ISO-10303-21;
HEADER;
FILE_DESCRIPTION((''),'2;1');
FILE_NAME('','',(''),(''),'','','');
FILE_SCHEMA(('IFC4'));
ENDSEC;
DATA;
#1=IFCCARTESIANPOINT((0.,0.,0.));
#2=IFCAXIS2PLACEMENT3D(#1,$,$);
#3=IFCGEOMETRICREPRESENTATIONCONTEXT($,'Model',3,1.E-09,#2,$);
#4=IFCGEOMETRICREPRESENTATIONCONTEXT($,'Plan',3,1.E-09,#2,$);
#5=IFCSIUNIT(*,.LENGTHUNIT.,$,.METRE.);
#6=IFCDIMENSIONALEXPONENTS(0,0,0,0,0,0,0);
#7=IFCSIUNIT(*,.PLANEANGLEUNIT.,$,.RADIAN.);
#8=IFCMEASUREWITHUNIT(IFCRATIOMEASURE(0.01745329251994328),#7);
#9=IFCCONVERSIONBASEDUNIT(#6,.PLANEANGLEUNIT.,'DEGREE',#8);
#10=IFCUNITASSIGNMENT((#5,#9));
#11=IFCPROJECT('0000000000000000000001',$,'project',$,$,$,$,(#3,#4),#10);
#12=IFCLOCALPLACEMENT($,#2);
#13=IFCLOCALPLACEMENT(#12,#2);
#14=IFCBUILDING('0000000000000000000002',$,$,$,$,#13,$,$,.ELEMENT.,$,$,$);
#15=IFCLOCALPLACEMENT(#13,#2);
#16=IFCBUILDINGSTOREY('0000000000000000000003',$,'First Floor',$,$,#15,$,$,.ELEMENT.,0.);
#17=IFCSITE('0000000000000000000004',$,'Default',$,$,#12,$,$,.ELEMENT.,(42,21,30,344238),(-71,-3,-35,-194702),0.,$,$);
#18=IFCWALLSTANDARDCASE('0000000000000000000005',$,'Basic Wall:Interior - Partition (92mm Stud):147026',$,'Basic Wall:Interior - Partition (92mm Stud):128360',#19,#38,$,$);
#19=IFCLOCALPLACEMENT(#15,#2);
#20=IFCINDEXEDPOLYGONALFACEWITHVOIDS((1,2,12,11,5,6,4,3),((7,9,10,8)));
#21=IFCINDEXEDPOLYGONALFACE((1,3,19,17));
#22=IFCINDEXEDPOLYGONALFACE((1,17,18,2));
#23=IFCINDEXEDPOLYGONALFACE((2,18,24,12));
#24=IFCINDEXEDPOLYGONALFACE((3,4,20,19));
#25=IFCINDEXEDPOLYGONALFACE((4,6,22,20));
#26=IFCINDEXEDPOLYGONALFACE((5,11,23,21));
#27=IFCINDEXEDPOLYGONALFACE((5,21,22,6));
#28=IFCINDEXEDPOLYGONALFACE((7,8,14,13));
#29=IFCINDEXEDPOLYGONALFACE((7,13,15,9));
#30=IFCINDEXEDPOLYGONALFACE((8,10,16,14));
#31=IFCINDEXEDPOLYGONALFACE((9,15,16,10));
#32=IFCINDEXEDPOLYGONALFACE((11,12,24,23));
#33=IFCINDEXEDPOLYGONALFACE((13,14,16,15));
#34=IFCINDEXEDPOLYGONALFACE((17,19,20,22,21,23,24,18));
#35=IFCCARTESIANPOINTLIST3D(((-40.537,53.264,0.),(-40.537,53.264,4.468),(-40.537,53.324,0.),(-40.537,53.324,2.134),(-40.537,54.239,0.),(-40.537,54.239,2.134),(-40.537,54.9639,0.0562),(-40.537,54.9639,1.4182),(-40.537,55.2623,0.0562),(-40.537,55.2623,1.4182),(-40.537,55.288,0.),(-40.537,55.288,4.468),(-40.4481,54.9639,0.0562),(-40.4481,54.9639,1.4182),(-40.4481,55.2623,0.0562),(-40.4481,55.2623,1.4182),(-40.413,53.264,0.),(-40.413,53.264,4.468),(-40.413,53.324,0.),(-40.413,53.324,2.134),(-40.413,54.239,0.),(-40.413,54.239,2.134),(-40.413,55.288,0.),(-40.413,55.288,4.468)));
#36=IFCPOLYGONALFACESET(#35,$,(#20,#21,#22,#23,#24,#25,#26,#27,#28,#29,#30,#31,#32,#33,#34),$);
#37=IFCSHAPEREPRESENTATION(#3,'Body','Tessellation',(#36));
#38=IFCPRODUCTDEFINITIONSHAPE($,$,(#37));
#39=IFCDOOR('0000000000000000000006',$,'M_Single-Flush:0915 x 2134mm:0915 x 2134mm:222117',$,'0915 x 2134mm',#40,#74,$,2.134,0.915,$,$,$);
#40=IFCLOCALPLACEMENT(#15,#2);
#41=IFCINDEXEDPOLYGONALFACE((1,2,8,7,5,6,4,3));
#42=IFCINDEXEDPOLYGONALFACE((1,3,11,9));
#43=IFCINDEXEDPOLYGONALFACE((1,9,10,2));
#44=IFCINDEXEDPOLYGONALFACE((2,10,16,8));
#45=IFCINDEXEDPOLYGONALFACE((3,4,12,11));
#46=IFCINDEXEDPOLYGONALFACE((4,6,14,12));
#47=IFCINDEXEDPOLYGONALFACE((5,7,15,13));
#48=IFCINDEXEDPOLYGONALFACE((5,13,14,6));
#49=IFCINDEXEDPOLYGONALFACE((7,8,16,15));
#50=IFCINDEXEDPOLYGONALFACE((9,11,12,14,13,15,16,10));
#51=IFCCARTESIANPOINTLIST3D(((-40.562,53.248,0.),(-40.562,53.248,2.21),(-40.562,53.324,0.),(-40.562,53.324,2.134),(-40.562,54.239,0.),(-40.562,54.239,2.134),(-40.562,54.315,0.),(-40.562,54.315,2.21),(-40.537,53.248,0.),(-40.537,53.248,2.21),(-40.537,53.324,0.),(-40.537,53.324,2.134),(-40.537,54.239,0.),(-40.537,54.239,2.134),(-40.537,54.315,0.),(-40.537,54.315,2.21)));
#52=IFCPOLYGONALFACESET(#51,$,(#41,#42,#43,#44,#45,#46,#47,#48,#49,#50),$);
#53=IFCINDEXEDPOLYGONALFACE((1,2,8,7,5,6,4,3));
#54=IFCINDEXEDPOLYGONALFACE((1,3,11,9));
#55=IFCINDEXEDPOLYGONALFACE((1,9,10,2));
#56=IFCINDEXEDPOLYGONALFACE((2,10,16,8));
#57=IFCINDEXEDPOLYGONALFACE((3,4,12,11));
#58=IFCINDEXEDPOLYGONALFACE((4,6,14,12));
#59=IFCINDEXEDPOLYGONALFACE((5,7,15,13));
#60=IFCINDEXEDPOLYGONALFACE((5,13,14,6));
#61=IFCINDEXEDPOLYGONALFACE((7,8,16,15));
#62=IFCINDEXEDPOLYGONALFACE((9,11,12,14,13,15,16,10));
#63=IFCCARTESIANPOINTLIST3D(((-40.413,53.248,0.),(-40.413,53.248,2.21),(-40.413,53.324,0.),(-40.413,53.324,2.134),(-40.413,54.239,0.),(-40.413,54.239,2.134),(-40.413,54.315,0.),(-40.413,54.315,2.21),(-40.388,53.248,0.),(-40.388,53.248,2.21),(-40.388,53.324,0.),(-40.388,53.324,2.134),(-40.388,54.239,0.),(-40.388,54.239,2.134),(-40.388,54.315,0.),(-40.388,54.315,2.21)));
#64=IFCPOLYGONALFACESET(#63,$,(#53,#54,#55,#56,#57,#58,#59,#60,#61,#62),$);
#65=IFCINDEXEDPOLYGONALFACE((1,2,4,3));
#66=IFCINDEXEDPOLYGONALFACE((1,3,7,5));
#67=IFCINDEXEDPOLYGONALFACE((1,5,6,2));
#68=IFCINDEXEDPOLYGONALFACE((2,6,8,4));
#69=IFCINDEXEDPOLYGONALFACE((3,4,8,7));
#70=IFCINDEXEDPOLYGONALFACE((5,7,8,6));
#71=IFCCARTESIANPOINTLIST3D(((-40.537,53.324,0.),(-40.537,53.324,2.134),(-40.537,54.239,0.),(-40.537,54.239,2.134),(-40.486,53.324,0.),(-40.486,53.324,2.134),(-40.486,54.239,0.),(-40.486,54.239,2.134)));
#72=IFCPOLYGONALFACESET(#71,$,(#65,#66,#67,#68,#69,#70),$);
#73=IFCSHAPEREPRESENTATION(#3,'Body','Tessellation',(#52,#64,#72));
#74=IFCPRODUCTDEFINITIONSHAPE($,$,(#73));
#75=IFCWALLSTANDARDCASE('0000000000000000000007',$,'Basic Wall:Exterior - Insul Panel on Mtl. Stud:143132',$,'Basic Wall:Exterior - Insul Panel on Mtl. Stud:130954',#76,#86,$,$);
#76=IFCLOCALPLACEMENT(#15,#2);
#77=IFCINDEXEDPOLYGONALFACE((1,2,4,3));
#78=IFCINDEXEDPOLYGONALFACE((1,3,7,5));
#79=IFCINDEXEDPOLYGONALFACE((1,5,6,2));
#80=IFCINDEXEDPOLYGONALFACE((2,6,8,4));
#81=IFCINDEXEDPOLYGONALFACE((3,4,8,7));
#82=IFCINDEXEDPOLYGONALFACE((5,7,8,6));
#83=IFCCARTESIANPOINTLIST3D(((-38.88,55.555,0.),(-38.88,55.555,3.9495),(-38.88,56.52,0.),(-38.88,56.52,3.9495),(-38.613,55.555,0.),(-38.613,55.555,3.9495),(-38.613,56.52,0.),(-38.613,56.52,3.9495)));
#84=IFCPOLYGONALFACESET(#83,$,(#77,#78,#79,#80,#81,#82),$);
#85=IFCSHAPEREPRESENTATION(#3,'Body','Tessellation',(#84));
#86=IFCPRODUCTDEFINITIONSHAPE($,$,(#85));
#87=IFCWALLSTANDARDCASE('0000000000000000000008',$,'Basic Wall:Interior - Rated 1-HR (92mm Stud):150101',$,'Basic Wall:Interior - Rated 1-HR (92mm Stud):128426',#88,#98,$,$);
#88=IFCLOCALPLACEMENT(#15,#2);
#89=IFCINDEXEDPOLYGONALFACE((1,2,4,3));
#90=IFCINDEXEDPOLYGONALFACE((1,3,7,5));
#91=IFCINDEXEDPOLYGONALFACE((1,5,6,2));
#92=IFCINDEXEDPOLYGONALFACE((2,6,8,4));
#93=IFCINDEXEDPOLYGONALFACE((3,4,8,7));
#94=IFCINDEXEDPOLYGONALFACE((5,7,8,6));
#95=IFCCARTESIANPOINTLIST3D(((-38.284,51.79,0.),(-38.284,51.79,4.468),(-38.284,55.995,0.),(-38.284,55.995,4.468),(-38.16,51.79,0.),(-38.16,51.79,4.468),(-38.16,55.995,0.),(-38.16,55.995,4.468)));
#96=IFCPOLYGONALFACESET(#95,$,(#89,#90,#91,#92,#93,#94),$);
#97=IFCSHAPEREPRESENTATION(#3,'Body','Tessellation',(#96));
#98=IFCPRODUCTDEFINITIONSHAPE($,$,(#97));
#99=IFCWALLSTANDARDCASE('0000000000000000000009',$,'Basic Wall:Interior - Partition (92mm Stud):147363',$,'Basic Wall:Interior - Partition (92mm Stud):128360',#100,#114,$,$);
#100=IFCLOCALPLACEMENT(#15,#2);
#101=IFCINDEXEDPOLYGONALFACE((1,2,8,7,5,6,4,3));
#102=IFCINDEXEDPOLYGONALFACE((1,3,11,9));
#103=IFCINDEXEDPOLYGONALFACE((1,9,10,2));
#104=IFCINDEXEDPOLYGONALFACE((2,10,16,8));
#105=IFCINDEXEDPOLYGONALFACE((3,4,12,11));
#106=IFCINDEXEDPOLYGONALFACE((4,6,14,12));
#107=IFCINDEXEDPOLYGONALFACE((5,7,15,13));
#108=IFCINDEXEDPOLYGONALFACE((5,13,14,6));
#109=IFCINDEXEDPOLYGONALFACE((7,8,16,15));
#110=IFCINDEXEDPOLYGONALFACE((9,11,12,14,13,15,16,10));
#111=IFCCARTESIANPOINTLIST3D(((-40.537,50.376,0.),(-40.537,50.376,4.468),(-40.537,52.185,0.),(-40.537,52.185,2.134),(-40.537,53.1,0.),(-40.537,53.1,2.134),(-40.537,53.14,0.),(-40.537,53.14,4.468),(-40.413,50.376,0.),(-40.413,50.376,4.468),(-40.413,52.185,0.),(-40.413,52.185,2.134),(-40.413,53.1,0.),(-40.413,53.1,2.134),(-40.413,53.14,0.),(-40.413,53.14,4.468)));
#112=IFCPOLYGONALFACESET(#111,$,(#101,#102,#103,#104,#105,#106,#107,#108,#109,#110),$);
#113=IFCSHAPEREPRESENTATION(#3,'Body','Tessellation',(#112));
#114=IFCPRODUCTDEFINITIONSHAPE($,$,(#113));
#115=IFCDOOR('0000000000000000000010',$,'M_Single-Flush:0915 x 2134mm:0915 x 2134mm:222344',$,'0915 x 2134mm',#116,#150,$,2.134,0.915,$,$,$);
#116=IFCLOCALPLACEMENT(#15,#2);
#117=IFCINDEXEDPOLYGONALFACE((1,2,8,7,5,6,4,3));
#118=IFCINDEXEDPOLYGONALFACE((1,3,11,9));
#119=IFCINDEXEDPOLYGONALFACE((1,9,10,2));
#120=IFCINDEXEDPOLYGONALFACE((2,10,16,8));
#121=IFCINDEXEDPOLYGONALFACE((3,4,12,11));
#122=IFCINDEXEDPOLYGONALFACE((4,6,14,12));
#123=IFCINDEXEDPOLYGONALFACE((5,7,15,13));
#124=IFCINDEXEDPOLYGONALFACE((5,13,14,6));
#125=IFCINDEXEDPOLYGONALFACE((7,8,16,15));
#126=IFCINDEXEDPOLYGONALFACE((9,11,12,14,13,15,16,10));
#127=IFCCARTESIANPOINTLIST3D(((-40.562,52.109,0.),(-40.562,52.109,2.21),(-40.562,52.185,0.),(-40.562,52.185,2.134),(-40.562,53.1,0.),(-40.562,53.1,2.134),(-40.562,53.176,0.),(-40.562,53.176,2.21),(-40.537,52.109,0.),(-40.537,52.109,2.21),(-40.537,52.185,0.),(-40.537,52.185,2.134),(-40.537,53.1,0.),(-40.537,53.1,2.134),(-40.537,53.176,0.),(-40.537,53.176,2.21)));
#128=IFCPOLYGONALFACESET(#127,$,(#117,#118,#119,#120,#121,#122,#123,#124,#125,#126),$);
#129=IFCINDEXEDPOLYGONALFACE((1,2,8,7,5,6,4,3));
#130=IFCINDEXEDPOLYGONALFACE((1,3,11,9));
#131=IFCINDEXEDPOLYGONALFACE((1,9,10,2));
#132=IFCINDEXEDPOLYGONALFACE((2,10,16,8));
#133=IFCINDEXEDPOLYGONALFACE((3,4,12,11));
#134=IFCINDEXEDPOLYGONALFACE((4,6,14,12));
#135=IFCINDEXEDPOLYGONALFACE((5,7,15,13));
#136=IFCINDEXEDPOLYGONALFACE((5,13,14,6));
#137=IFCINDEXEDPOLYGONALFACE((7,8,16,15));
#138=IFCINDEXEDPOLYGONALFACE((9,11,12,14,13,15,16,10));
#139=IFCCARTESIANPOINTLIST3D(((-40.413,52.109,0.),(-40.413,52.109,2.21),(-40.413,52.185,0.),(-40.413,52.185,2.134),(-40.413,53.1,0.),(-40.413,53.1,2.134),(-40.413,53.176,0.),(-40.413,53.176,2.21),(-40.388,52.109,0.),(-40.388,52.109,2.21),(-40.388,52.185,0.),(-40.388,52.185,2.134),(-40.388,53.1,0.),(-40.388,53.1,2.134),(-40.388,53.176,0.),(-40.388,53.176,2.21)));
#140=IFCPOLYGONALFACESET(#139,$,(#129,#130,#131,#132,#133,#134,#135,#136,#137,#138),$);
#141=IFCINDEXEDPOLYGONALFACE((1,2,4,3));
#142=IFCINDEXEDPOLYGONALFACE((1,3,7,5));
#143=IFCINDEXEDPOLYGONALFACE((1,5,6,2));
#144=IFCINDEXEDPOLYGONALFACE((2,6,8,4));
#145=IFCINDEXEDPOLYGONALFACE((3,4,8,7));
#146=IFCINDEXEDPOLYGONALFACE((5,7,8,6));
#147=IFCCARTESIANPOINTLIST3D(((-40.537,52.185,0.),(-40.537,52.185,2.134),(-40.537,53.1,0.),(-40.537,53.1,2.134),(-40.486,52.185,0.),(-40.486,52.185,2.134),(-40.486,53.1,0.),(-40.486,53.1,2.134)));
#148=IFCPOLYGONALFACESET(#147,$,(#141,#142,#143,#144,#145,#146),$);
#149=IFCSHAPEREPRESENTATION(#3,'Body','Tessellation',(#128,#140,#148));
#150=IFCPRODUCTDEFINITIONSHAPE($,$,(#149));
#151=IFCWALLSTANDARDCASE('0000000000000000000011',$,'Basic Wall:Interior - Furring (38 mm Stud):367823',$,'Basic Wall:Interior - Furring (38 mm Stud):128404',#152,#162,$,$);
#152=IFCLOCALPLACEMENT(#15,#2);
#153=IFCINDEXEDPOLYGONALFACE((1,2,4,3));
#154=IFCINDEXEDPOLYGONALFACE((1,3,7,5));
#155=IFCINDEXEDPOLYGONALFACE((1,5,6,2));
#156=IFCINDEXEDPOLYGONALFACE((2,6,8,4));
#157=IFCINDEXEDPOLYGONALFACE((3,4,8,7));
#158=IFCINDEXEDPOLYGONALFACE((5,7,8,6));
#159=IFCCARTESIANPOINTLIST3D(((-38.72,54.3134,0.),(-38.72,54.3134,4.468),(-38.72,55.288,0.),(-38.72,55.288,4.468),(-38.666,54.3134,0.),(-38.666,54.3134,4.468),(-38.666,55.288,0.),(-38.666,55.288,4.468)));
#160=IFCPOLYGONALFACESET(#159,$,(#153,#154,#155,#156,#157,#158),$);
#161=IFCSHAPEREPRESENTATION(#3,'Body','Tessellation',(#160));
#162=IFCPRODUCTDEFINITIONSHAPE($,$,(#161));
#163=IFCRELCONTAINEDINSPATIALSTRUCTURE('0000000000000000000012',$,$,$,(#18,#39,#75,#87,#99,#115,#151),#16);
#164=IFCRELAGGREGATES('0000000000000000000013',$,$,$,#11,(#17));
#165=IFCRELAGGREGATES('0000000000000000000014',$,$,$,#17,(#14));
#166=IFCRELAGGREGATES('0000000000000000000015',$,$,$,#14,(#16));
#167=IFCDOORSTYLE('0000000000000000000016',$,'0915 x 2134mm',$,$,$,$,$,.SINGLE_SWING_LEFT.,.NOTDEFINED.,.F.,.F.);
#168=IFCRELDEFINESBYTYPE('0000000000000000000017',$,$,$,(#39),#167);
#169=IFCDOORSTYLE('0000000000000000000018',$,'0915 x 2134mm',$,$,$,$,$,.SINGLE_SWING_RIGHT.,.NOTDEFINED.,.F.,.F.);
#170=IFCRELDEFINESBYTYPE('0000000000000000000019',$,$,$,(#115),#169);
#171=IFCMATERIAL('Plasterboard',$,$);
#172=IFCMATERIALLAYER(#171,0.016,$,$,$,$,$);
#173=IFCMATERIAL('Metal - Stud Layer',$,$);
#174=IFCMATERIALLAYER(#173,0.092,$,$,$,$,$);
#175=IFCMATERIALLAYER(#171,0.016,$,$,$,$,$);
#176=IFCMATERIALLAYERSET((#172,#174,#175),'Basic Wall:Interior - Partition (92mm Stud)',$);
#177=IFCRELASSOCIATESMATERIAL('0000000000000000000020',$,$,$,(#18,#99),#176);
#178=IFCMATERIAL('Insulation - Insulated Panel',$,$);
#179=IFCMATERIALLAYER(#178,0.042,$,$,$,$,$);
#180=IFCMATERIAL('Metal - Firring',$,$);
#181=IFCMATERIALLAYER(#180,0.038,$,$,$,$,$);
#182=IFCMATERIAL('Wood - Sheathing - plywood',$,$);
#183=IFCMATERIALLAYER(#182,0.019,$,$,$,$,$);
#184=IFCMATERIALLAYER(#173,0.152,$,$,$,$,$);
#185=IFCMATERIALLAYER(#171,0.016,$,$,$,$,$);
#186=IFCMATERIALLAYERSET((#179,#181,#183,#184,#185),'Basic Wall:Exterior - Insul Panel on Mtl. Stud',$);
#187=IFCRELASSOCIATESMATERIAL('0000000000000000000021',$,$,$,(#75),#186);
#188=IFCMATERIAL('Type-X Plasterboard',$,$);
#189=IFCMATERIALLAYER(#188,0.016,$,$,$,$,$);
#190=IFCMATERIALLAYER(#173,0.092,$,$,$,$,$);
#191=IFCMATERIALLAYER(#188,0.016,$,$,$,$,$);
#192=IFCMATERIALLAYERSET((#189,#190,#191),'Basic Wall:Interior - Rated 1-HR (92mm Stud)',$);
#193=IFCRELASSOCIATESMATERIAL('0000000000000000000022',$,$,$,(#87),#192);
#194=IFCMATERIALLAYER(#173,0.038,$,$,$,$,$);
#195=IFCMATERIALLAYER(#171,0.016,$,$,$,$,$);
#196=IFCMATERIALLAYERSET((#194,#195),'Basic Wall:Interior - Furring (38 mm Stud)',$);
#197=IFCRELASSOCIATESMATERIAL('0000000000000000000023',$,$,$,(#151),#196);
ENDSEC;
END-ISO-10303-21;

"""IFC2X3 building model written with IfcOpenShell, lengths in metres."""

from ifc_helpers import new_model, entity, si_unit, converted_unit, frame, frame_2d, origin, origin_2d_with_axis, place, context, project, spatial, polyline, rectangle, outline, extrude, source, transform, mapped, material, layer, layer_set, layer_usage, type_object, type_shapes, element, fill, save


model = new_model("IFC2X3")

# Units and contexts
model_context = context("Model", 3, precision=1e-09, world=origin())
plan_context = context("Plan", 3, precision=1e-09, world=origin())
ifc_project = project(units=[si_unit("LENGTHUNIT", "METRE"), converted_unit("PLANEANGLEUNIT", "DEGREE", entity("IfcRatioMeasure", 0.01745329251994328), si_unit("PLANEANGLEUNIT", "RADIAN"), dimensions=[0, 0, 0, 0, 0, 0, 0])], contexts=[model_context, plan_context])

# Site, building, storey
site_placement = place(None, origin())
site = spatial("IfcSite", under=ifc_project, at=site_placement, Name="Default", CompositionType="ELEMENT", RefLatitude=(42, 21, 30, 344238), RefLongitude=(-71, -3, -35, -194702), RefElevation=0.0)
building_placement = place(site_placement, origin())
building = spatial("IfcBuilding", under=site, at=building_placement, CompositionType="ELEMENT")
storey_placement = place(building_placement, origin())
storey = spatial("IfcBuildingStorey", under=building, at=storey_placement, Name="First Floor", CompositionType="ELEMENT", Elevation=0.0)

# Shared definitions
ifc_material_1 = material(Name="Insulation - Insulated Panel")
ifc_layer_1 = layer(ifc_material_1, 0.042)
ifc_material_2 = material(Name="Metal - Firring")
ifc_layer_2 = layer(ifc_material_2, 0.038)
ifc_material_3 = material(Name="Wood - Sheathing - plywood")
ifc_layer_3 = layer(ifc_material_3, 0.019)
ifc_material_4 = material(Name="Metal - Stud Layer")
ifc_layer_4 = layer(ifc_material_4, 0.152)
ifc_material_5 = material(Name="Plasterboard")
ifc_layer_5 = layer(ifc_material_5, 0.016)
ifc_layer_set_1 = layer_set([ifc_layer_1, ifc_layer_2, ifc_layer_3, ifc_layer_4, ifc_layer_5], Name="Basic Wall:Exterior - Insul Panel on Mtl. Stud")
ifc_layer_usage_1 = layer_usage(ifc_layer_set_1, "AXIS2", "NEGATIVE", 0.1335)
ifc_material_6 = material(Name="Type-X Plasterboard")
ifc_layer_6 = layer(ifc_material_6, 0.016)
ifc_layer_7 = layer(ifc_material_4, 0.092)
ifc_layer_8 = layer(ifc_material_6, 0.016)
ifc_layer_set_2 = layer_set([ifc_layer_6, ifc_layer_7, ifc_layer_8], Name="Basic Wall:Interior - Rated 1-HR (92mm Stud)")
ifc_layer_usage_2 = layer_usage(ifc_layer_set_2, "AXIS2", "NEGATIVE", 0.062)

# Shared definitions
ifc_layer_9 = layer(ifc_material_5, 0.016)
ifc_layer_10 = layer(ifc_material_4, 0.092)
ifc_layer_11 = layer(ifc_material_5, 0.016)
ifc_layer_set_3 = layer_set([ifc_layer_9, ifc_layer_10, ifc_layer_11], Name="Basic Wall:Interior - Partition (92mm Stud)")
ifc_layer_usage_3 = layer_usage(ifc_layer_set_3, "AXIS2", "NEGATIVE", 0.062)

# Wall, openings, door
wall_1_placement = place(storey_placement, frame((-40.475, 55.288, 0.0), z_axis=(0.0, 0.0, 1.0), x_axis=(0.0, -1.0, 0.0)))
wall_1 = element("IfcWallStandardCase", 1, at=wall_1_placement, inside=storey, material=ifc_layer_usage_3, Name="Basic Wall:Interior - Partition (92mm Stud):147026", ObjectType="Basic Wall:Interior - Partition (92mm Stud):128360", context=model_context, shape_type="SweptSolid", body=[
    extrude(rectangle(XDim=2.024, YDim=0.124, at=frame_2d((1.012, 0.0), x_axis=(-1.0, 0.0))), origin(), (0.0, 0.0, 1.0), 4.468),
])
opening_1_placement = place(wall_1_placement, origin())
element("IfcOpeningElement", 2, at=opening_1_placement, cuts=wall_1, ObjectType="Opening", context=model_context, shape_type="SweptSolid", body=[
    extrude(rectangle(XDim=1.3621, YDim=0.2984, at=origin_2d_with_axis()), frame((0.1749, -0.1255, 0.7372), z_axis=(0.0, 1.0, 0.0), x_axis=(0.0, 0.0, -1.0)), (0.0, 0.0, 1.0), 0.1524),
])
opening_2_placement = place(wall_1_placement, frame((1.964, 0.062, 0.0)))
opening_2 = element("IfcOpeningElement", 3, at=opening_2_placement, cuts=wall_1, ObjectType="Opening", context=model_context, shape_type="SweptSolid", body=[
    extrude(rectangle(XDim=0.915, YDim=2.134, at=frame_2d((1.067, 0.4575), x_axis=(0.0, -1.0))), frame((0.0, 0.0, 0.0), z_axis=(0.0, -1.0, 0.0), x_axis=(0.0, 0.0, 1.0)), (0.0, 0.0, 1.0), 0.124),
])
door_style_1 = type_object("IfcDoorStyle", Name="0915 x 2134mm", ConstructionType="NOTDEFINED", OperationType="SINGLE_SWING_LEFT", ParameterTakesPrecedence=False, Sizeable=False)
shared_shape_1 = source(origin(), model_context, "Body", "SweptSolid", [
    extrude(outline(polyline([(-0.5335, -1.124), (0.5335, -1.124), (0.5335, 1.086), (0.4575, 1.086), (0.4575, -1.048), (-0.4575, -1.048), (-0.4575, 1.086), (-0.5335, 1.086), (-0.5335, -1.124)])), frame((0.4575, 0.149, 1.086), z_axis=(0.0, -1.0, 0.0), x_axis=(-1.0, 0.0, 0.0)), (0.0, 0.0, 1.0), 0.025),
    extrude(outline(polyline([(-1.124, -0.5335), (1.086, -0.5335), (1.086, -0.4575), (-1.048, -0.4575), (-1.048, 0.4575), (1.086, 0.4575), (1.086, 0.5335), (-1.124, 0.5335), (-1.124, -0.5335)])), frame((0.4575, 0.0, 1.086), z_axis=(0.0, -1.0, 0.0), x_axis=(0.0, 0.0, -1.0)), (0.0, 0.0, 1.0), 0.025),
    extrude(rectangle(XDim=0.915, YDim=0.051, at=origin_2d_with_axis()), frame((0.4575, 0.0985, 0.0)), (0.0, 0.0, 1.0), 2.134),
])
type_shapes(door_style_1, [shared_shape_1])
door_1_placement = place(opening_2_placement, frame((0.0, 0.0, 0.0), z_axis=(0.0, 0.0, 1.0), x_axis=(-1.0, 0.0, 0.0)))
door_1 = element("IfcDoor", 4, at=door_1_placement, inside=storey, type_object=door_style_1, Name="M_Single-Flush:0915 x 2134mm:0915 x 2134mm:222117", ObjectType="0915 x 2134mm", OverallHeight=2.134, OverallWidth=0.915, context=model_context, shape_type="MappedRepresentation", body=[
    mapped(shared_shape_1, transform((0.0, 0.0, 0.0), scale=1.0)),
])
fill(opening_2, door_1)

# Walls
wall_2_placement = place(storey_placement, frame((-38.7465, 55.555, 0.0), z_axis=(0.0, 0.0, 1.0), x_axis=(0.0, 1.0, 0.0)))
element("IfcWallStandardCase", 5, at=wall_2_placement, inside=storey, material=ifc_layer_usage_1, Name="Basic Wall:Exterior - Insul Panel on Mtl. Stud:143132", ObjectType="Basic Wall:Exterior - Insul Panel on Mtl. Stud:130954", context=model_context, shape_type="SweptSolid", body=[
    extrude(rectangle(XDim=0.965, YDim=0.267, at=frame_2d((0.4825, 0.0), x_axis=(-1.0, 0.0))), origin(), (0.0, 0.0, 1.0), 3.9495),
])
wall_3_placement = place(storey_placement, frame((-38.222, 55.995, 0.0), z_axis=(0.0, 0.0, 1.0), x_axis=(0.0, -1.0, 0.0)))
element("IfcWallStandardCase", 6, at=wall_3_placement, inside=storey, material=ifc_layer_usage_2, Name="Basic Wall:Interior - Rated 1-HR (92mm Stud):150101", ObjectType="Basic Wall:Interior - Rated 1-HR (92mm Stud):128426", context=model_context, shape_type="SweptSolid", body=[
    extrude(rectangle(XDim=4.205, YDim=0.124, at=frame_2d((2.1025, 0.0), x_axis=(-1.0, 0.0))), origin(), (0.0, 0.0, 1.0), 4.468),
])

# Wall, opening, door
wall_4_placement = place(storey_placement, frame((-40.475, 53.14, 0.0), z_axis=(0.0, 0.0, 1.0), x_axis=(0.0, -1.0, 0.0)))
wall_4 = element("IfcWallStandardCase", 7, at=wall_4_placement, inside=storey, material=ifc_layer_usage_3, Name="Basic Wall:Interior - Partition (92mm Stud):147363", ObjectType="Basic Wall:Interior - Partition (92mm Stud):128360", context=model_context, shape_type="SweptSolid", body=[
    extrude(rectangle(XDim=2.764, YDim=0.124, at=frame_2d((1.382, 0.0), x_axis=(-1.0, 0.0))), origin(), (0.0, 0.0, 1.0), 4.468),
])
opening_3_placement = place(wall_4_placement, frame((0.955, 0.062, 0.0)))
opening_3 = element("IfcOpeningElement", 8, at=opening_3_placement, cuts=wall_4, ObjectType="Opening", context=model_context, shape_type="SweptSolid", body=[
    extrude(rectangle(XDim=0.915, YDim=2.134, at=frame_2d((1.067, 0.4575), x_axis=(0.0, 1.0))), frame((0.0, 0.0, 0.0), z_axis=(0.0, -1.0, 0.0), x_axis=(0.0, 0.0, 1.0)), (0.0, 0.0, 1.0), 0.124),
])
door_style_2 = type_object("IfcDoorStyle", Name="0915 x 2134mm", ConstructionType="NOTDEFINED", OperationType="SINGLE_SWING_RIGHT", ParameterTakesPrecedence=False, Sizeable=False)
shared_shape_2 = source(origin(), model_context, "Body", "SweptSolid", [
    extrude(outline(polyline([(-0.5335, -1.124), (0.5335, -1.124), (0.5335, 1.086), (0.4575, 1.086), (0.4575, -1.048), (-0.4575, -1.048), (-0.4575, 1.086), (-0.5335, 1.086), (-0.5335, -1.124)])), frame((0.4575, 0.124, 1.086), z_axis=(0.0, 1.0, 0.0), x_axis=(1.0, 0.0, 0.0)), (0.0, 0.0, 1.0), 0.025),
    extrude(outline(polyline([(-1.124, -0.5335), (1.086, -0.5335), (1.086, -0.4575), (-1.048, -0.4575), (-1.048, 0.4575), (1.086, 0.4575), (1.086, 0.5335), (-1.124, 0.5335), (-1.124, -0.5335)])), frame((0.4575, -0.025, 1.086), z_axis=(0.0, 1.0, 0.0), x_axis=(0.0, 0.0, -1.0)), (0.0, 0.0, 1.0), 0.025),
    extrude(rectangle(XDim=0.051, YDim=0.915, at=origin_2d_with_axis()), frame((0.4575, 0.0985, 0.0), z_axis=(0.0, 0.0, 1.0), x_axis=(0.0, 1.0, 0.0)), (0.0, 0.0, 1.0), 2.134),
])
type_shapes(door_style_2, [shared_shape_2])
door_2_placement = place(opening_3_placement, frame((0.0, 0.0, 0.0), z_axis=(0.0, 0.0, 1.0), x_axis=(-1.0, 0.0, 0.0)))
door_2 = element("IfcDoor", 9, at=door_2_placement, inside=storey, type_object=door_style_2, Name="M_Single-Flush:0915 x 2134mm:0915 x 2134mm:222344", ObjectType="0915 x 2134mm", OverallHeight=2.134, OverallWidth=0.915, context=model_context, shape_type="MappedRepresentation", body=[
    mapped(shared_shape_2, transform((0.0, 0.0, 0.0), scale=1.0)),
])
fill(opening_3, door_2)

# Wall
ifc_layer_12 = layer(ifc_material_4, 0.038)
ifc_layer_13 = layer(ifc_material_5, 0.016)
ifc_layer_set_4 = layer_set([ifc_layer_12, ifc_layer_13], Name="Basic Wall:Interior - Furring (38 mm Stud)")
ifc_layer_usage_4 = layer_usage(ifc_layer_set_4, "AXIS2", "NEGATIVE", 0.027)
wall_5_placement = place(storey_placement, frame((-38.693, 55.288, 0.0), z_axis=(0.0, 0.0, 1.0), x_axis=(0.0, -1.0, 0.0)))
element("IfcWallStandardCase", 10, at=wall_5_placement, inside=storey, material=ifc_layer_usage_4, Name="Basic Wall:Interior - Furring (38 mm Stud):367823", ObjectType="Basic Wall:Interior - Furring (38 mm Stud):128404", context=model_context, shape_type="SweptSolid", body=[
    extrude(rectangle(XDim=0.9746, YDim=0.054, at=frame_2d((0.4873, 0.0), x_axis=(-1.0, 0.0))), origin(), (0.0, 0.0, 1.0), 4.468),
])

save(model, "model.ifc")
